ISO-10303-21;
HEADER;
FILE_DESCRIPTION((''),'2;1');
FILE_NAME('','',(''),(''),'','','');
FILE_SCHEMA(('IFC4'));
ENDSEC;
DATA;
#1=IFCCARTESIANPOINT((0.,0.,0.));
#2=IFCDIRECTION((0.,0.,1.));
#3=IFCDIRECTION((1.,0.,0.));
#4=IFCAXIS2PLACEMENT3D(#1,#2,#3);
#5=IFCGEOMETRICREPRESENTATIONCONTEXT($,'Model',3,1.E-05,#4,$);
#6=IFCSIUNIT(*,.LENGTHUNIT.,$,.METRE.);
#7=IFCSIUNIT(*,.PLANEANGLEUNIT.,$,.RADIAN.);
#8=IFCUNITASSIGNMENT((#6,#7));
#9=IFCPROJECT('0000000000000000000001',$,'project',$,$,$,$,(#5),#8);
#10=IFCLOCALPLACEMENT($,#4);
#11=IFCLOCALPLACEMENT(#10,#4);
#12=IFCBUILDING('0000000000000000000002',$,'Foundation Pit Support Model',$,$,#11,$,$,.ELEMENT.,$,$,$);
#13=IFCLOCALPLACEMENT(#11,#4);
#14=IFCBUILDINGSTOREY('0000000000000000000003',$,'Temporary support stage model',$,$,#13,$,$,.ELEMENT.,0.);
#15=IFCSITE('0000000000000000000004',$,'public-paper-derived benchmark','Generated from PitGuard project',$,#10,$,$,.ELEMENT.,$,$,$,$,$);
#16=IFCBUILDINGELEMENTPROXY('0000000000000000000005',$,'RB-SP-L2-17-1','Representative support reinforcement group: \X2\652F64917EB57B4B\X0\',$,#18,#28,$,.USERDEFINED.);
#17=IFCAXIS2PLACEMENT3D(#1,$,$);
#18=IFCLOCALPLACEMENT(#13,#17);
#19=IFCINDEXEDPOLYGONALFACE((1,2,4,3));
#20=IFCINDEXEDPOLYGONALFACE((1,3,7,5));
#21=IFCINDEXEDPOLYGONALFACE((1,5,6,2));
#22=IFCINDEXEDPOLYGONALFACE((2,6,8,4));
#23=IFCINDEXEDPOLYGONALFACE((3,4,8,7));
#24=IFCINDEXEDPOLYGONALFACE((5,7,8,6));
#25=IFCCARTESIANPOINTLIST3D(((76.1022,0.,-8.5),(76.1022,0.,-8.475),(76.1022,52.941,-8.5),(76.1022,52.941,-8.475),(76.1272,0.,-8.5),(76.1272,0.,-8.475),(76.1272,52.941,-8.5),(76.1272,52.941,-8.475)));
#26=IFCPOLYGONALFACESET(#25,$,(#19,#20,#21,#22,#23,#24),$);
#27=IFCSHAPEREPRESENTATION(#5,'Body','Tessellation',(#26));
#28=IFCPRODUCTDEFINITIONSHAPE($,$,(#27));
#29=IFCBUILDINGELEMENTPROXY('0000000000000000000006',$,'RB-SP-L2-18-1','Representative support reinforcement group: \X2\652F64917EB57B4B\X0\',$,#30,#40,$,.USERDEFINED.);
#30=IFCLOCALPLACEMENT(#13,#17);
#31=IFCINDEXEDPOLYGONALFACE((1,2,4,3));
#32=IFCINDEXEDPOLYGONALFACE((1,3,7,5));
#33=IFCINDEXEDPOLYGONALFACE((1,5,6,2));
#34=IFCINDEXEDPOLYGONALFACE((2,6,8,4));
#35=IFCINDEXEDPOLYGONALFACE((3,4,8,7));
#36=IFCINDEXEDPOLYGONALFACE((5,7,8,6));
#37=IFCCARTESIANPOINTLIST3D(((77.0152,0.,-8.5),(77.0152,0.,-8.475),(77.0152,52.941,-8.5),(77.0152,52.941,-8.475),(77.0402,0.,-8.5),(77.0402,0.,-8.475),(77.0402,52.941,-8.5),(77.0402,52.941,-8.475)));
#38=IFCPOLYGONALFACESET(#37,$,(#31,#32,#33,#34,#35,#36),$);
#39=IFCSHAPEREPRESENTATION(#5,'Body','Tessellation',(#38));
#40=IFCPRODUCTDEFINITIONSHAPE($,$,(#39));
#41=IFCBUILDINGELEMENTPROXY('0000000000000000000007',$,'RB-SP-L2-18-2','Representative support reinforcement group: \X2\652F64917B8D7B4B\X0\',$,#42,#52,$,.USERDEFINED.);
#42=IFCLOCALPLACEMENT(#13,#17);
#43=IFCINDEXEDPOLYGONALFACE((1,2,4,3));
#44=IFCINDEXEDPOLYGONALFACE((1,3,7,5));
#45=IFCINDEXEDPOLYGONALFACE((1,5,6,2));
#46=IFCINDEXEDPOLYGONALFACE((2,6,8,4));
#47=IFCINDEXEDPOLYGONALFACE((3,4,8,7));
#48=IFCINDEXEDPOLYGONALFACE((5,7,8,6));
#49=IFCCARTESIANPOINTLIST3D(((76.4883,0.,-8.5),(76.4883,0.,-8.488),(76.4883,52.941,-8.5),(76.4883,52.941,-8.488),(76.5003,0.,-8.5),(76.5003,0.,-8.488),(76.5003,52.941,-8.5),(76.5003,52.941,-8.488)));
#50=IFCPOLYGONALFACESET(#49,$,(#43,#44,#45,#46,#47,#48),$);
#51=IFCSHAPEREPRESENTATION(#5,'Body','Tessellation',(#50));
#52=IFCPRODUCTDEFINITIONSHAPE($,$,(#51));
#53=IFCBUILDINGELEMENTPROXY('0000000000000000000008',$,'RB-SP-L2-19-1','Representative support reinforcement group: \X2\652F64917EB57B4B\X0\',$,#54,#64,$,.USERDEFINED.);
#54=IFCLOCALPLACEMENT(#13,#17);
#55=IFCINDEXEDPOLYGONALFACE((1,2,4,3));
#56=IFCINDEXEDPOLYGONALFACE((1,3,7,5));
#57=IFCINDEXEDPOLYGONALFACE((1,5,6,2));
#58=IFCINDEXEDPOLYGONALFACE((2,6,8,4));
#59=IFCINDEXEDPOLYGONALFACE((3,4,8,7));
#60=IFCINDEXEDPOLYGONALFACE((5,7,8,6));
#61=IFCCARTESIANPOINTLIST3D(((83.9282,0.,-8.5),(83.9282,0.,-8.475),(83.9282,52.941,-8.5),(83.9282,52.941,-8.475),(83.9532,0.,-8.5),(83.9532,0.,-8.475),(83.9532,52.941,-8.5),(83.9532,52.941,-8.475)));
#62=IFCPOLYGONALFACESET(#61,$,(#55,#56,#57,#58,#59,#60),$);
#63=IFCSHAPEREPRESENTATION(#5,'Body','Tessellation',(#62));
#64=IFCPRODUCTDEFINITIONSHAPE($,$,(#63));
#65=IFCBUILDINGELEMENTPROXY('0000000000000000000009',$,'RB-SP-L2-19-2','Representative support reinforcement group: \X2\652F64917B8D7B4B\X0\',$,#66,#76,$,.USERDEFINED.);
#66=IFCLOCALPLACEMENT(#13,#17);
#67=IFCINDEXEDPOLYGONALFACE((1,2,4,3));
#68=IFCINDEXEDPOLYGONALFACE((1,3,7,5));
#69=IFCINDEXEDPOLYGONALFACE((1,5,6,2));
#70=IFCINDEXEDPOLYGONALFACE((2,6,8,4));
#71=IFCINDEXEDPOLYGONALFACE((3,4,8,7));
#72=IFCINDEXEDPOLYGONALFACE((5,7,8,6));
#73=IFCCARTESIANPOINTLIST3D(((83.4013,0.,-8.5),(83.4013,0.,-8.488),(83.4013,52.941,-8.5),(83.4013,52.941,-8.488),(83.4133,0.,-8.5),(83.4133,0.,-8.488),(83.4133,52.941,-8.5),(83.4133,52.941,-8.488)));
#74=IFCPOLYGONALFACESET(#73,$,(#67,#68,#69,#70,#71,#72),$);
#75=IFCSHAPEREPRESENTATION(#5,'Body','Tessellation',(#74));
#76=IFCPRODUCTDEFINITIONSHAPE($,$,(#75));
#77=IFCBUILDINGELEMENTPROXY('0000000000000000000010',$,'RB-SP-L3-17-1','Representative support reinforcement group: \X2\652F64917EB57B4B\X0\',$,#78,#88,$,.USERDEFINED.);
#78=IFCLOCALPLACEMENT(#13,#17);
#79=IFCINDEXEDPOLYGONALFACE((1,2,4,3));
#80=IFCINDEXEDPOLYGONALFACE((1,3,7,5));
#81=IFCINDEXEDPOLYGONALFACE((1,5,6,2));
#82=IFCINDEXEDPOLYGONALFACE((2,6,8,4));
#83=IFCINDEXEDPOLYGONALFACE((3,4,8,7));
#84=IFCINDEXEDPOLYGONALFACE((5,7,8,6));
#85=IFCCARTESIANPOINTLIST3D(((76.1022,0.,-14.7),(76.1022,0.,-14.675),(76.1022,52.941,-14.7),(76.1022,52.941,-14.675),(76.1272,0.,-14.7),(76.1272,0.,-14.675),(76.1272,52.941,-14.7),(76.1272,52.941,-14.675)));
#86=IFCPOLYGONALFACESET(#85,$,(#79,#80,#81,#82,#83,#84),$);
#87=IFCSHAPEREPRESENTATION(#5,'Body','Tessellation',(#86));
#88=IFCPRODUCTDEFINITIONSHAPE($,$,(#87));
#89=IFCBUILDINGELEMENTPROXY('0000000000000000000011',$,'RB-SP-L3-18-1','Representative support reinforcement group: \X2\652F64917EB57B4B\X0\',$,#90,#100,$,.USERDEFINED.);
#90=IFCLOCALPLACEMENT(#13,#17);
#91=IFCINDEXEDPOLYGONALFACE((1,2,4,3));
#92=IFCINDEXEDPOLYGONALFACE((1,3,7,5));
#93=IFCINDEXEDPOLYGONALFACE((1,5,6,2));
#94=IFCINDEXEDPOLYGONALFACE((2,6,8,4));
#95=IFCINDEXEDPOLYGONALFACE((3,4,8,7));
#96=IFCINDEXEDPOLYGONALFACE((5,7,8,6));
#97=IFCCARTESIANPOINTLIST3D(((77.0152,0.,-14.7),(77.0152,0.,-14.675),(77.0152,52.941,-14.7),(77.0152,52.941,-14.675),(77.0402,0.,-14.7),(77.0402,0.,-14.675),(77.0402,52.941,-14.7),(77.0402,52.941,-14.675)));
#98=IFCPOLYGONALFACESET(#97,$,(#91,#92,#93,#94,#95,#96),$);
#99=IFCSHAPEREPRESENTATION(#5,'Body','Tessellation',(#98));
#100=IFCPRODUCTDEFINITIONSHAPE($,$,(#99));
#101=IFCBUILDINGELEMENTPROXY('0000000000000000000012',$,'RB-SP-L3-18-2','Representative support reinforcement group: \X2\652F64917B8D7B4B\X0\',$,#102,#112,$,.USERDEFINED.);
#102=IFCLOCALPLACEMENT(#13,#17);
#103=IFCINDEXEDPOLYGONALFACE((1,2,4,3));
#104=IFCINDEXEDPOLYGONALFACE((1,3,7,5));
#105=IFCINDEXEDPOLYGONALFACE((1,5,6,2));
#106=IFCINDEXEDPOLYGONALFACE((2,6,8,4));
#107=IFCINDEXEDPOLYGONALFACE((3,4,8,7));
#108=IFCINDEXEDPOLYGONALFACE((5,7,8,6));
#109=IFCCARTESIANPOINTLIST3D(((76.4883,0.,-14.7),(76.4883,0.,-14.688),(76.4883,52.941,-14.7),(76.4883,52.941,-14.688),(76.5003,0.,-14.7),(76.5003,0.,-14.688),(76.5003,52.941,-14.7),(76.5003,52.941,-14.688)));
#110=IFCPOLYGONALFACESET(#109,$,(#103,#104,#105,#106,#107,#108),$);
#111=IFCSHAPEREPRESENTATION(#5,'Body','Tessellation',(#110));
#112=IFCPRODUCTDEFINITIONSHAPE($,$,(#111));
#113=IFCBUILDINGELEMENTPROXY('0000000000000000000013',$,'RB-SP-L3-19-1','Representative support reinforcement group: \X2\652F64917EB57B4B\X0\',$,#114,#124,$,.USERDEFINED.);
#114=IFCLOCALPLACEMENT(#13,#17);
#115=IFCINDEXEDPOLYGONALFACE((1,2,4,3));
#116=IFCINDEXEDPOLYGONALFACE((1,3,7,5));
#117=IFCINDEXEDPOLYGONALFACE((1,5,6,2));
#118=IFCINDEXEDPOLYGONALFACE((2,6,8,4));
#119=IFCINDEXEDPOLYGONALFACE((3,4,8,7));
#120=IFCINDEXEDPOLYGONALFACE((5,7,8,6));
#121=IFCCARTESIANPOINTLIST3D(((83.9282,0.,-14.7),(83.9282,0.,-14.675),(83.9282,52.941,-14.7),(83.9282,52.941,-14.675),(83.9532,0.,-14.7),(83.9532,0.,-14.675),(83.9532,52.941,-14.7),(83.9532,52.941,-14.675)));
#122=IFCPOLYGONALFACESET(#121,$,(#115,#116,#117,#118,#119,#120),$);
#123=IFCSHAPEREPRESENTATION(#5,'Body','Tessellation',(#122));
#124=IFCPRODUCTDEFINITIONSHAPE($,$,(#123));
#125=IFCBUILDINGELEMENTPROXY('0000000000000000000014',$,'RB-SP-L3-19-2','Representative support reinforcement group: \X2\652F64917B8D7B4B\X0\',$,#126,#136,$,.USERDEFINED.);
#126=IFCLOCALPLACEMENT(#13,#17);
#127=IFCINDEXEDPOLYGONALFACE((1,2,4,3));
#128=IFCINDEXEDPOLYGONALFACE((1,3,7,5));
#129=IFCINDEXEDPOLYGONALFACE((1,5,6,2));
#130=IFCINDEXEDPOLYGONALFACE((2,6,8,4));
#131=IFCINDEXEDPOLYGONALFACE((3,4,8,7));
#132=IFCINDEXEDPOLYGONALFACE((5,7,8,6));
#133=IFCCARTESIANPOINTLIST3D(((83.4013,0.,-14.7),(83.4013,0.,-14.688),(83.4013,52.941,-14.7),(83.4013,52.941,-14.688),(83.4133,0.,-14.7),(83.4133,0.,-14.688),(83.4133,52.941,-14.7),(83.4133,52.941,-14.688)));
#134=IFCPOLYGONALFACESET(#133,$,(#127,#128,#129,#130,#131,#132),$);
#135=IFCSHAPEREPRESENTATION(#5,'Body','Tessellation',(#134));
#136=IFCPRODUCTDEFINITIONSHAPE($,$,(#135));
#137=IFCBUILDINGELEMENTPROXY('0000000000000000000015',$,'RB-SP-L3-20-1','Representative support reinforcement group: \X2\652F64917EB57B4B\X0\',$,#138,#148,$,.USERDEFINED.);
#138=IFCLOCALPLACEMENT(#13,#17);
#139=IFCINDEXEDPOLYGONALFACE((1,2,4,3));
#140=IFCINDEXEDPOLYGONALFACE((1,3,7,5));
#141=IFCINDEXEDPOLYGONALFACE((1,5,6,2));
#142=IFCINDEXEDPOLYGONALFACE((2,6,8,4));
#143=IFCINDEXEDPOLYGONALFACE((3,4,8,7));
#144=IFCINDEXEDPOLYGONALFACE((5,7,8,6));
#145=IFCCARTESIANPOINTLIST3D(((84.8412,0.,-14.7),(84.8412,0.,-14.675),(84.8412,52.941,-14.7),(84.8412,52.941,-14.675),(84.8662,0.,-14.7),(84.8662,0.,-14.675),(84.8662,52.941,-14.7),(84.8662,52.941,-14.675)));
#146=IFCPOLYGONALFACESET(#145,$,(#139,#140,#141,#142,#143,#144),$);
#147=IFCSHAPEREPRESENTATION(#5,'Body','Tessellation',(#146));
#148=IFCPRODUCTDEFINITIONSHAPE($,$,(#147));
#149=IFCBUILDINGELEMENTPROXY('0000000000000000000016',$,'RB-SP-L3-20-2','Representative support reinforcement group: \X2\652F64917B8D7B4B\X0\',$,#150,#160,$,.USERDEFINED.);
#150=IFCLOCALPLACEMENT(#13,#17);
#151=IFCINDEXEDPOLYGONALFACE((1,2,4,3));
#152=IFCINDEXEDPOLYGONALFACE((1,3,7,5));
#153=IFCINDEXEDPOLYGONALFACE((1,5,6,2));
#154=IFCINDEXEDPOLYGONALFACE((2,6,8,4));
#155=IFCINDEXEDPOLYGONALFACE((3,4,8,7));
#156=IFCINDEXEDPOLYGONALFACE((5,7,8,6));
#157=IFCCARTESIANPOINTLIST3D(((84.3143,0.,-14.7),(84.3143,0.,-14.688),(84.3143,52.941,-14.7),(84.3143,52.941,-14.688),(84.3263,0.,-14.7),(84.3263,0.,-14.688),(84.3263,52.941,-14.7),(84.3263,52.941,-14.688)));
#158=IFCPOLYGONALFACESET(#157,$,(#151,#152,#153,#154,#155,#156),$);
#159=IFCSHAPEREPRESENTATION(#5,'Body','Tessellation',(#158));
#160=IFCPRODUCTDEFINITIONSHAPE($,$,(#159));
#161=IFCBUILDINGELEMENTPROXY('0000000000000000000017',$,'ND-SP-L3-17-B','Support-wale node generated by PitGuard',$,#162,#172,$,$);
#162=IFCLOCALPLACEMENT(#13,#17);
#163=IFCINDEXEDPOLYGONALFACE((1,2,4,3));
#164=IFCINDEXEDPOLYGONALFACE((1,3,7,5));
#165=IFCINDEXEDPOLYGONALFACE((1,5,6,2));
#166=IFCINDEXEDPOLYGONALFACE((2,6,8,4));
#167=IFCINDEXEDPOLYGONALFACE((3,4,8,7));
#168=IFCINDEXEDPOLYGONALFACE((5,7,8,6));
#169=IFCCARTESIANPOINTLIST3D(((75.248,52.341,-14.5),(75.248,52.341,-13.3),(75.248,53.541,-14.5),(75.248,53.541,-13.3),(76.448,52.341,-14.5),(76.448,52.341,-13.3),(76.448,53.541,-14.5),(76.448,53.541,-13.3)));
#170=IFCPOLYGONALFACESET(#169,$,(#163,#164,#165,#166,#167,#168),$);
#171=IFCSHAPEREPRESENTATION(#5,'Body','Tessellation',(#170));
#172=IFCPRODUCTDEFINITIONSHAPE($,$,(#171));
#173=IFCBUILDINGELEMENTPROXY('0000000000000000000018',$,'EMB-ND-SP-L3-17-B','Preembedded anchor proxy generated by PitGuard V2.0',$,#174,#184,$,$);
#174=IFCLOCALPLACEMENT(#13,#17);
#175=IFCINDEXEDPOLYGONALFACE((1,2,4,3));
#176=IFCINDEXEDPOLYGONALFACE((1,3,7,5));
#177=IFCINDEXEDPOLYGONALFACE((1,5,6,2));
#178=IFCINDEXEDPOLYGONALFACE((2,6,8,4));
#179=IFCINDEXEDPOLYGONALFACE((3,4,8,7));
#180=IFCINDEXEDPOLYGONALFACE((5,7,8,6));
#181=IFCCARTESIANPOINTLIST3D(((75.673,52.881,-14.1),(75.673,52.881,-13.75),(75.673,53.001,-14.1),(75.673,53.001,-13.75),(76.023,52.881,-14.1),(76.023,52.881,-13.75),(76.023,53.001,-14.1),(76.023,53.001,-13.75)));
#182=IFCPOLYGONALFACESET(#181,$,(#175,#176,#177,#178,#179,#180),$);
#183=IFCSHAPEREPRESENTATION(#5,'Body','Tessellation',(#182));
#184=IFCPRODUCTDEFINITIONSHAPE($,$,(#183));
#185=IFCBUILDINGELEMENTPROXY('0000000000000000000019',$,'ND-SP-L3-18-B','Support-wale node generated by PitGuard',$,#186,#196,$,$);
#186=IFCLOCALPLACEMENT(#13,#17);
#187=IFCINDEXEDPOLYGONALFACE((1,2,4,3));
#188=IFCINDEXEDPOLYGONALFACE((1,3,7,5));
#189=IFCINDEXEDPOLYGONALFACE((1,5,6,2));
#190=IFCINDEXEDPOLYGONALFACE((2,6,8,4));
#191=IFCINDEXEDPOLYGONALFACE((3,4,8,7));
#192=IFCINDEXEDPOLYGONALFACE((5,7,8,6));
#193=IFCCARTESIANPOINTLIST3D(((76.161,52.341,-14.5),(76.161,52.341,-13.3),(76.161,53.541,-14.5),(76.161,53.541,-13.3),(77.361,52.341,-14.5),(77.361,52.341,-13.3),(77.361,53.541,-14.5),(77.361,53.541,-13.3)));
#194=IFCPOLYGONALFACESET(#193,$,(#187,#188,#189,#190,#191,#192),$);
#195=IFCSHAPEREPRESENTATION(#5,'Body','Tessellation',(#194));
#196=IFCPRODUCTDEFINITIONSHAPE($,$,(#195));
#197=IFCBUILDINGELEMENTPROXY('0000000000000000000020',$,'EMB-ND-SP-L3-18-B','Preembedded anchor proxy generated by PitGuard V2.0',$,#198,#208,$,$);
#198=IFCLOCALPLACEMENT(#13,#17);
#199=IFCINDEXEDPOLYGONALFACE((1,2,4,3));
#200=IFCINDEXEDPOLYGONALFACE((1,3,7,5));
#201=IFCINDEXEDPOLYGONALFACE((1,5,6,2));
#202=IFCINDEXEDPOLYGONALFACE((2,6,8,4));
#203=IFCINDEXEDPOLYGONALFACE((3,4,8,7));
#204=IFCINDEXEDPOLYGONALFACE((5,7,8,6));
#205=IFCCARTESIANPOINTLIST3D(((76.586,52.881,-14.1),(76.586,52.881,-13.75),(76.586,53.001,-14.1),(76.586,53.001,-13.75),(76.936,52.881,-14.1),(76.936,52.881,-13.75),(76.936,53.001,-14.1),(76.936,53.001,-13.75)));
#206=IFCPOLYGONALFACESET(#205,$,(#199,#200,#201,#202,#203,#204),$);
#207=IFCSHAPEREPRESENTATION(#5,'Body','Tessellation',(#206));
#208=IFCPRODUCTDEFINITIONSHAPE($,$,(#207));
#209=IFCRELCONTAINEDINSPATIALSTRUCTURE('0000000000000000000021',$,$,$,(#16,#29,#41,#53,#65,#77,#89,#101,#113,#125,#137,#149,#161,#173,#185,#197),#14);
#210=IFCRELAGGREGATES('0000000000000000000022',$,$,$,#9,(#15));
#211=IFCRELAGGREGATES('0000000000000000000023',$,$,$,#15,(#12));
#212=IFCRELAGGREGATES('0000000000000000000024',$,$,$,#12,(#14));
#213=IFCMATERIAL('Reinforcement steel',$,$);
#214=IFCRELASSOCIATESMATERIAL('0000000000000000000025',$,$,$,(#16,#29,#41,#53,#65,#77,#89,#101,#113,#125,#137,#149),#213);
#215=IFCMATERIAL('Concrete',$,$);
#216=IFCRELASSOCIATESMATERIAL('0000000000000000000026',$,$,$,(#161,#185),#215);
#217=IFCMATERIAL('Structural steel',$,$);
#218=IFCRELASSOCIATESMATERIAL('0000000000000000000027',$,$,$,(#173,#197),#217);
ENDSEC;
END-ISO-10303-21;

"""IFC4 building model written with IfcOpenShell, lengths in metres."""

from ifc_helpers import new_model, si_unit, frame, origin_with_axes, origin_2d, place, context, project, spatial, rectangle, extrude, material, element, save


model = new_model("IFC4")

# Units and contexts
model_context = context("Model", 3, precision=1e-05, world=origin_with_axes())
ifc_project = project(units=[si_unit("LENGTHUNIT", "METRE"), si_unit("PLANEANGLEUNIT", "RADIAN")], contexts=[model_context])

# Site, building, storey
site_placement = place(None, origin_with_axes())
site = spatial("IfcSite", under=ifc_project, at=site_placement, Name="public-paper-derived benchmark", Description="Generated from PitGuard project", CompositionType="ELEMENT")
building_placement = place(site_placement, origin_with_axes())
building = spatial("IfcBuilding", under=site, at=building_placement, Name="Foundation Pit Support Model", CompositionType="ELEMENT")
storey_placement = place(building_placement, origin_with_axes())
storey = spatial("IfcBuildingStorey", under=building, at=storey_placement, Name="Temporary support stage model", CompositionType="ELEMENT", Elevation=0.0)

# Shared definitions
ifc_material_1 = material(Name="Structural steel")

# Shared definitions
ifc_material_2 = material(Name="Concrete")

# Building element proxies
ifc_material_3 = material(Name="Reinforcement steel")
for number, where, z_axis, x_axis, name in (
    (1, (76.1147, 26.4705, -8.5), (0.0, 0.0, 1.0), (0.0, 1.0, 0.0), "RB-SP-L2-17-1"),
    (2, (77.0277, 26.4705, -8.5), (0.0, 0.0, 1.0), (0.0, 1.0, 0.0), "RB-SP-L2-18-1"),
):
    element("IfcBuildingElementProxy", number, at=place(storey_placement, frame(where, z_axis=z_axis, x_axis=x_axis)), inside=storey, material=ifc_material_3, Name=name, Description="Representative support reinforcement group: 支撑纵筋", PredefinedType="USERDEFINED", context=model_context, shape_type="SweptSolid", body=[
        extrude(rectangle(XDim=52.941, YDim=0.025, at=origin_2d()), origin_with_axes(), (0.0, 0.0, 1.0), 0.025),
    ])
proxy_1_placement = place(storey_placement, frame((76.4943, 26.4705, -8.5), z_axis=(0.0, 0.0, 1.0), x_axis=(0.0, 1.0, 0.0)))
element("IfcBuildingElementProxy", 3, at=proxy_1_placement, inside=storey, material=ifc_material_3, Name="RB-SP-L2-18-2", Description="Representative support reinforcement group: 支撑箍筋", PredefinedType="USERDEFINED", context=model_context, shape_type="SweptSolid", body=[
    extrude(rectangle(XDim=52.941, YDim=0.012, at=origin_2d()), origin_with_axes(), (0.0, 0.0, 1.0), 0.012),
])
proxy_2_placement = place(storey_placement, frame((83.9407, 26.4705, -8.5), z_axis=(0.0, 0.0, 1.0), x_axis=(0.0, 1.0, 0.0)))
element("IfcBuildingElementProxy", 4, at=proxy_2_placement, inside=storey, material=ifc_material_3, Name="RB-SP-L2-19-1", Description="Representative support reinforcement group: 支撑纵筋", PredefinedType="USERDEFINED", context=model_context, shape_type="SweptSolid", body=[
    extrude(rectangle(XDim=52.941, YDim=0.025, at=origin_2d()), origin_with_axes(), (0.0, 0.0, 1.0), 0.025),
])
proxy_3_placement = place(storey_placement, frame((83.4073, 26.4705, -8.5), z_axis=(0.0, 0.0, 1.0), x_axis=(0.0, 1.0, 0.0)))
element("IfcBuildingElementProxy", 5, at=proxy_3_placement, inside=storey, material=ifc_material_3, Name="RB-SP-L2-19-2", Description="Representative support reinforcement group: 支撑箍筋", PredefinedType="USERDEFINED", context=model_context, shape_type="SweptSolid", body=[
    extrude(rectangle(XDim=52.941, YDim=0.012, at=origin_2d()), origin_with_axes(), (0.0, 0.0, 1.0), 0.012),
])
for number, where, z_axis, x_axis, name in (
    (6, (76.1147, 26.4705, -14.7), (0.0, 0.0, 1.0), (0.0, 1.0, 0.0), "RB-SP-L3-17-1"),
    (7, (77.0277, 26.4705, -14.7), (0.0, 0.0, 1.0), (0.0, 1.0, 0.0), "RB-SP-L3-18-1"),
):
    element("IfcBuildingElementProxy", number, at=place(storey_placement, frame(where, z_axis=z_axis, x_axis=x_axis)), inside=storey, material=ifc_material_3, Name=name, Description="Representative support reinforcement group: 支撑纵筋", PredefinedType="USERDEFINED", context=model_context, shape_type="SweptSolid", body=[
        extrude(rectangle(XDim=52.941, YDim=0.025, at=origin_2d()), origin_with_axes(), (0.0, 0.0, 1.0), 0.025),
    ])
proxy_4_placement = place(storey_placement, frame((76.4943, 26.4705, -14.7), z_axis=(0.0, 0.0, 1.0), x_axis=(0.0, 1.0, 0.0)))
element("IfcBuildingElementProxy", 8, at=proxy_4_placement, inside=storey, material=ifc_material_3, Name="RB-SP-L3-18-2", Description="Representative support reinforcement group: 支撑箍筋", PredefinedType="USERDEFINED", context=model_context, shape_type="SweptSolid", body=[
    extrude(rectangle(XDim=52.941, YDim=0.012, at=origin_2d()), origin_with_axes(), (0.0, 0.0, 1.0), 0.012),
])
proxy_5_placement = place(storey_placement, frame((83.9407, 26.4705, -14.7), z_axis=(0.0, 0.0, 1.0), x_axis=(0.0, 1.0, 0.0)))
element("IfcBuildingElementProxy", 9, at=proxy_5_placement, inside=storey, material=ifc_material_3, Name="RB-SP-L3-19-1", Description="Representative support reinforcement group: 支撑纵筋", PredefinedType="USERDEFINED", context=model_context, shape_type="SweptSolid", body=[
    extrude(rectangle(XDim=52.941, YDim=0.025, at=origin_2d()), origin_with_axes(), (0.0, 0.0, 1.0), 0.025),
])
proxy_6_placement = place(storey_placement, frame((83.4073, 26.4705, -14.7), z_axis=(0.0, 0.0, 1.0), x_axis=(0.0, 1.0, 0.0)))
element("IfcBuildingElementProxy", 10, at=proxy_6_placement, inside=storey, material=ifc_material_3, Name="RB-SP-L3-19-2", Description="Representative support reinforcement group: 支撑箍筋", PredefinedType="USERDEFINED", context=model_context, shape_type="SweptSolid", body=[
    extrude(rectangle(XDim=52.941, YDim=0.012, at=origin_2d()), origin_with_axes(), (0.0, 0.0, 1.0), 0.012),
])
proxy_7_placement = place(storey_placement, frame((84.8537, 26.4705, -14.7), z_axis=(0.0, 0.0, 1.0), x_axis=(0.0, 1.0, 0.0)))
element("IfcBuildingElementProxy", 11, at=proxy_7_placement, inside=storey, material=ifc_material_3, Name="RB-SP-L3-20-1", Description="Representative support reinforcement group: 支撑纵筋", PredefinedType="USERDEFINED", context=model_context, shape_type="SweptSolid", body=[
    extrude(rectangle(XDim=52.941, YDim=0.025, at=origin_2d()), origin_with_axes(), (0.0, 0.0, 1.0), 0.025),
])
proxy_8_placement = place(storey_placement, frame((84.3203, 26.4705, -14.7), z_axis=(0.0, 0.0, 1.0), x_axis=(0.0, 1.0, 0.0)))
element("IfcBuildingElementProxy", 12, at=proxy_8_placement, inside=storey, material=ifc_material_3, Name="RB-SP-L3-20-2", Description="Representative support reinforcement group: 支撑箍筋", PredefinedType="USERDEFINED", context=model_context, shape_type="SweptSolid", body=[
    extrude(rectangle(XDim=52.941, YDim=0.012, at=origin_2d()), origin_with_axes(), (0.0, 0.0, 1.0), 0.012),
])
proxy_9_placement = place(storey_placement, frame((75.848, 52.941, -14.5), z_axis=(0.0, 0.0, 1.0), x_axis=(1.0, 0.0, 0.0)))
element("IfcBuildingElementProxy", 13, at=proxy_9_placement, inside=storey, material=ifc_material_2, Name="ND-SP-L3-17-B", Description="Support-wale node generated by PitGuard", context=model_context, shape_type="SweptSolid", body=[
    extrude(rectangle(XDim=1.2, YDim=1.2, at=origin_2d()), origin_with_axes(), (0.0, 0.0, 1.0), 1.2),
])
proxy_10_placement = place(storey_placement, frame((75.848, 52.941, -14.1), z_axis=(0.0, 0.0, 1.0), x_axis=(1.0, 0.0, 0.0)))
element("IfcBuildingElementProxy", 14, at=proxy_10_placement, inside=storey, material=ifc_material_1, Name="EMB-ND-SP-L3-17-B", Description="Preembedded anchor proxy generated by PitGuard V2.0", context=model_context, shape_type="SweptSolid", body=[
    extrude(rectangle(XDim=0.35, YDim=0.12, at=origin_2d()), origin_with_axes(), (0.0, 0.0, 1.0), 0.35),
])
proxy_11_placement = place(storey_placement, frame((76.761, 52.941, -14.5), z_axis=(0.0, 0.0, 1.0), x_axis=(1.0, 0.0, 0.0)))
element("IfcBuildingElementProxy", 15, at=proxy_11_placement, inside=storey, material=ifc_material_2, Name="ND-SP-L3-18-B", Description="Support-wale node generated by PitGuard", context=model_context, shape_type="SweptSolid", body=[
    extrude(rectangle(XDim=1.2, YDim=1.2, at=origin_2d()), origin_with_axes(), (0.0, 0.0, 1.0), 1.2),
])
proxy_12_placement = place(storey_placement, frame((76.761, 52.941, -14.1), z_axis=(0.0, 0.0, 1.0), x_axis=(1.0, 0.0, 0.0)))
element("IfcBuildingElementProxy", 16, at=proxy_12_placement, inside=storey, material=ifc_material_1, Name="EMB-ND-SP-L3-18-B", Description="Preembedded anchor proxy generated by PitGuard V2.0", context=model_context, shape_type="SweptSolid", body=[
    extrude(rectangle(XDim=0.35, YDim=0.12, at=origin_2d()), origin_with_axes(), (0.0, 0.0, 1.0), 0.35),
])

save(model, "model.ifc")
